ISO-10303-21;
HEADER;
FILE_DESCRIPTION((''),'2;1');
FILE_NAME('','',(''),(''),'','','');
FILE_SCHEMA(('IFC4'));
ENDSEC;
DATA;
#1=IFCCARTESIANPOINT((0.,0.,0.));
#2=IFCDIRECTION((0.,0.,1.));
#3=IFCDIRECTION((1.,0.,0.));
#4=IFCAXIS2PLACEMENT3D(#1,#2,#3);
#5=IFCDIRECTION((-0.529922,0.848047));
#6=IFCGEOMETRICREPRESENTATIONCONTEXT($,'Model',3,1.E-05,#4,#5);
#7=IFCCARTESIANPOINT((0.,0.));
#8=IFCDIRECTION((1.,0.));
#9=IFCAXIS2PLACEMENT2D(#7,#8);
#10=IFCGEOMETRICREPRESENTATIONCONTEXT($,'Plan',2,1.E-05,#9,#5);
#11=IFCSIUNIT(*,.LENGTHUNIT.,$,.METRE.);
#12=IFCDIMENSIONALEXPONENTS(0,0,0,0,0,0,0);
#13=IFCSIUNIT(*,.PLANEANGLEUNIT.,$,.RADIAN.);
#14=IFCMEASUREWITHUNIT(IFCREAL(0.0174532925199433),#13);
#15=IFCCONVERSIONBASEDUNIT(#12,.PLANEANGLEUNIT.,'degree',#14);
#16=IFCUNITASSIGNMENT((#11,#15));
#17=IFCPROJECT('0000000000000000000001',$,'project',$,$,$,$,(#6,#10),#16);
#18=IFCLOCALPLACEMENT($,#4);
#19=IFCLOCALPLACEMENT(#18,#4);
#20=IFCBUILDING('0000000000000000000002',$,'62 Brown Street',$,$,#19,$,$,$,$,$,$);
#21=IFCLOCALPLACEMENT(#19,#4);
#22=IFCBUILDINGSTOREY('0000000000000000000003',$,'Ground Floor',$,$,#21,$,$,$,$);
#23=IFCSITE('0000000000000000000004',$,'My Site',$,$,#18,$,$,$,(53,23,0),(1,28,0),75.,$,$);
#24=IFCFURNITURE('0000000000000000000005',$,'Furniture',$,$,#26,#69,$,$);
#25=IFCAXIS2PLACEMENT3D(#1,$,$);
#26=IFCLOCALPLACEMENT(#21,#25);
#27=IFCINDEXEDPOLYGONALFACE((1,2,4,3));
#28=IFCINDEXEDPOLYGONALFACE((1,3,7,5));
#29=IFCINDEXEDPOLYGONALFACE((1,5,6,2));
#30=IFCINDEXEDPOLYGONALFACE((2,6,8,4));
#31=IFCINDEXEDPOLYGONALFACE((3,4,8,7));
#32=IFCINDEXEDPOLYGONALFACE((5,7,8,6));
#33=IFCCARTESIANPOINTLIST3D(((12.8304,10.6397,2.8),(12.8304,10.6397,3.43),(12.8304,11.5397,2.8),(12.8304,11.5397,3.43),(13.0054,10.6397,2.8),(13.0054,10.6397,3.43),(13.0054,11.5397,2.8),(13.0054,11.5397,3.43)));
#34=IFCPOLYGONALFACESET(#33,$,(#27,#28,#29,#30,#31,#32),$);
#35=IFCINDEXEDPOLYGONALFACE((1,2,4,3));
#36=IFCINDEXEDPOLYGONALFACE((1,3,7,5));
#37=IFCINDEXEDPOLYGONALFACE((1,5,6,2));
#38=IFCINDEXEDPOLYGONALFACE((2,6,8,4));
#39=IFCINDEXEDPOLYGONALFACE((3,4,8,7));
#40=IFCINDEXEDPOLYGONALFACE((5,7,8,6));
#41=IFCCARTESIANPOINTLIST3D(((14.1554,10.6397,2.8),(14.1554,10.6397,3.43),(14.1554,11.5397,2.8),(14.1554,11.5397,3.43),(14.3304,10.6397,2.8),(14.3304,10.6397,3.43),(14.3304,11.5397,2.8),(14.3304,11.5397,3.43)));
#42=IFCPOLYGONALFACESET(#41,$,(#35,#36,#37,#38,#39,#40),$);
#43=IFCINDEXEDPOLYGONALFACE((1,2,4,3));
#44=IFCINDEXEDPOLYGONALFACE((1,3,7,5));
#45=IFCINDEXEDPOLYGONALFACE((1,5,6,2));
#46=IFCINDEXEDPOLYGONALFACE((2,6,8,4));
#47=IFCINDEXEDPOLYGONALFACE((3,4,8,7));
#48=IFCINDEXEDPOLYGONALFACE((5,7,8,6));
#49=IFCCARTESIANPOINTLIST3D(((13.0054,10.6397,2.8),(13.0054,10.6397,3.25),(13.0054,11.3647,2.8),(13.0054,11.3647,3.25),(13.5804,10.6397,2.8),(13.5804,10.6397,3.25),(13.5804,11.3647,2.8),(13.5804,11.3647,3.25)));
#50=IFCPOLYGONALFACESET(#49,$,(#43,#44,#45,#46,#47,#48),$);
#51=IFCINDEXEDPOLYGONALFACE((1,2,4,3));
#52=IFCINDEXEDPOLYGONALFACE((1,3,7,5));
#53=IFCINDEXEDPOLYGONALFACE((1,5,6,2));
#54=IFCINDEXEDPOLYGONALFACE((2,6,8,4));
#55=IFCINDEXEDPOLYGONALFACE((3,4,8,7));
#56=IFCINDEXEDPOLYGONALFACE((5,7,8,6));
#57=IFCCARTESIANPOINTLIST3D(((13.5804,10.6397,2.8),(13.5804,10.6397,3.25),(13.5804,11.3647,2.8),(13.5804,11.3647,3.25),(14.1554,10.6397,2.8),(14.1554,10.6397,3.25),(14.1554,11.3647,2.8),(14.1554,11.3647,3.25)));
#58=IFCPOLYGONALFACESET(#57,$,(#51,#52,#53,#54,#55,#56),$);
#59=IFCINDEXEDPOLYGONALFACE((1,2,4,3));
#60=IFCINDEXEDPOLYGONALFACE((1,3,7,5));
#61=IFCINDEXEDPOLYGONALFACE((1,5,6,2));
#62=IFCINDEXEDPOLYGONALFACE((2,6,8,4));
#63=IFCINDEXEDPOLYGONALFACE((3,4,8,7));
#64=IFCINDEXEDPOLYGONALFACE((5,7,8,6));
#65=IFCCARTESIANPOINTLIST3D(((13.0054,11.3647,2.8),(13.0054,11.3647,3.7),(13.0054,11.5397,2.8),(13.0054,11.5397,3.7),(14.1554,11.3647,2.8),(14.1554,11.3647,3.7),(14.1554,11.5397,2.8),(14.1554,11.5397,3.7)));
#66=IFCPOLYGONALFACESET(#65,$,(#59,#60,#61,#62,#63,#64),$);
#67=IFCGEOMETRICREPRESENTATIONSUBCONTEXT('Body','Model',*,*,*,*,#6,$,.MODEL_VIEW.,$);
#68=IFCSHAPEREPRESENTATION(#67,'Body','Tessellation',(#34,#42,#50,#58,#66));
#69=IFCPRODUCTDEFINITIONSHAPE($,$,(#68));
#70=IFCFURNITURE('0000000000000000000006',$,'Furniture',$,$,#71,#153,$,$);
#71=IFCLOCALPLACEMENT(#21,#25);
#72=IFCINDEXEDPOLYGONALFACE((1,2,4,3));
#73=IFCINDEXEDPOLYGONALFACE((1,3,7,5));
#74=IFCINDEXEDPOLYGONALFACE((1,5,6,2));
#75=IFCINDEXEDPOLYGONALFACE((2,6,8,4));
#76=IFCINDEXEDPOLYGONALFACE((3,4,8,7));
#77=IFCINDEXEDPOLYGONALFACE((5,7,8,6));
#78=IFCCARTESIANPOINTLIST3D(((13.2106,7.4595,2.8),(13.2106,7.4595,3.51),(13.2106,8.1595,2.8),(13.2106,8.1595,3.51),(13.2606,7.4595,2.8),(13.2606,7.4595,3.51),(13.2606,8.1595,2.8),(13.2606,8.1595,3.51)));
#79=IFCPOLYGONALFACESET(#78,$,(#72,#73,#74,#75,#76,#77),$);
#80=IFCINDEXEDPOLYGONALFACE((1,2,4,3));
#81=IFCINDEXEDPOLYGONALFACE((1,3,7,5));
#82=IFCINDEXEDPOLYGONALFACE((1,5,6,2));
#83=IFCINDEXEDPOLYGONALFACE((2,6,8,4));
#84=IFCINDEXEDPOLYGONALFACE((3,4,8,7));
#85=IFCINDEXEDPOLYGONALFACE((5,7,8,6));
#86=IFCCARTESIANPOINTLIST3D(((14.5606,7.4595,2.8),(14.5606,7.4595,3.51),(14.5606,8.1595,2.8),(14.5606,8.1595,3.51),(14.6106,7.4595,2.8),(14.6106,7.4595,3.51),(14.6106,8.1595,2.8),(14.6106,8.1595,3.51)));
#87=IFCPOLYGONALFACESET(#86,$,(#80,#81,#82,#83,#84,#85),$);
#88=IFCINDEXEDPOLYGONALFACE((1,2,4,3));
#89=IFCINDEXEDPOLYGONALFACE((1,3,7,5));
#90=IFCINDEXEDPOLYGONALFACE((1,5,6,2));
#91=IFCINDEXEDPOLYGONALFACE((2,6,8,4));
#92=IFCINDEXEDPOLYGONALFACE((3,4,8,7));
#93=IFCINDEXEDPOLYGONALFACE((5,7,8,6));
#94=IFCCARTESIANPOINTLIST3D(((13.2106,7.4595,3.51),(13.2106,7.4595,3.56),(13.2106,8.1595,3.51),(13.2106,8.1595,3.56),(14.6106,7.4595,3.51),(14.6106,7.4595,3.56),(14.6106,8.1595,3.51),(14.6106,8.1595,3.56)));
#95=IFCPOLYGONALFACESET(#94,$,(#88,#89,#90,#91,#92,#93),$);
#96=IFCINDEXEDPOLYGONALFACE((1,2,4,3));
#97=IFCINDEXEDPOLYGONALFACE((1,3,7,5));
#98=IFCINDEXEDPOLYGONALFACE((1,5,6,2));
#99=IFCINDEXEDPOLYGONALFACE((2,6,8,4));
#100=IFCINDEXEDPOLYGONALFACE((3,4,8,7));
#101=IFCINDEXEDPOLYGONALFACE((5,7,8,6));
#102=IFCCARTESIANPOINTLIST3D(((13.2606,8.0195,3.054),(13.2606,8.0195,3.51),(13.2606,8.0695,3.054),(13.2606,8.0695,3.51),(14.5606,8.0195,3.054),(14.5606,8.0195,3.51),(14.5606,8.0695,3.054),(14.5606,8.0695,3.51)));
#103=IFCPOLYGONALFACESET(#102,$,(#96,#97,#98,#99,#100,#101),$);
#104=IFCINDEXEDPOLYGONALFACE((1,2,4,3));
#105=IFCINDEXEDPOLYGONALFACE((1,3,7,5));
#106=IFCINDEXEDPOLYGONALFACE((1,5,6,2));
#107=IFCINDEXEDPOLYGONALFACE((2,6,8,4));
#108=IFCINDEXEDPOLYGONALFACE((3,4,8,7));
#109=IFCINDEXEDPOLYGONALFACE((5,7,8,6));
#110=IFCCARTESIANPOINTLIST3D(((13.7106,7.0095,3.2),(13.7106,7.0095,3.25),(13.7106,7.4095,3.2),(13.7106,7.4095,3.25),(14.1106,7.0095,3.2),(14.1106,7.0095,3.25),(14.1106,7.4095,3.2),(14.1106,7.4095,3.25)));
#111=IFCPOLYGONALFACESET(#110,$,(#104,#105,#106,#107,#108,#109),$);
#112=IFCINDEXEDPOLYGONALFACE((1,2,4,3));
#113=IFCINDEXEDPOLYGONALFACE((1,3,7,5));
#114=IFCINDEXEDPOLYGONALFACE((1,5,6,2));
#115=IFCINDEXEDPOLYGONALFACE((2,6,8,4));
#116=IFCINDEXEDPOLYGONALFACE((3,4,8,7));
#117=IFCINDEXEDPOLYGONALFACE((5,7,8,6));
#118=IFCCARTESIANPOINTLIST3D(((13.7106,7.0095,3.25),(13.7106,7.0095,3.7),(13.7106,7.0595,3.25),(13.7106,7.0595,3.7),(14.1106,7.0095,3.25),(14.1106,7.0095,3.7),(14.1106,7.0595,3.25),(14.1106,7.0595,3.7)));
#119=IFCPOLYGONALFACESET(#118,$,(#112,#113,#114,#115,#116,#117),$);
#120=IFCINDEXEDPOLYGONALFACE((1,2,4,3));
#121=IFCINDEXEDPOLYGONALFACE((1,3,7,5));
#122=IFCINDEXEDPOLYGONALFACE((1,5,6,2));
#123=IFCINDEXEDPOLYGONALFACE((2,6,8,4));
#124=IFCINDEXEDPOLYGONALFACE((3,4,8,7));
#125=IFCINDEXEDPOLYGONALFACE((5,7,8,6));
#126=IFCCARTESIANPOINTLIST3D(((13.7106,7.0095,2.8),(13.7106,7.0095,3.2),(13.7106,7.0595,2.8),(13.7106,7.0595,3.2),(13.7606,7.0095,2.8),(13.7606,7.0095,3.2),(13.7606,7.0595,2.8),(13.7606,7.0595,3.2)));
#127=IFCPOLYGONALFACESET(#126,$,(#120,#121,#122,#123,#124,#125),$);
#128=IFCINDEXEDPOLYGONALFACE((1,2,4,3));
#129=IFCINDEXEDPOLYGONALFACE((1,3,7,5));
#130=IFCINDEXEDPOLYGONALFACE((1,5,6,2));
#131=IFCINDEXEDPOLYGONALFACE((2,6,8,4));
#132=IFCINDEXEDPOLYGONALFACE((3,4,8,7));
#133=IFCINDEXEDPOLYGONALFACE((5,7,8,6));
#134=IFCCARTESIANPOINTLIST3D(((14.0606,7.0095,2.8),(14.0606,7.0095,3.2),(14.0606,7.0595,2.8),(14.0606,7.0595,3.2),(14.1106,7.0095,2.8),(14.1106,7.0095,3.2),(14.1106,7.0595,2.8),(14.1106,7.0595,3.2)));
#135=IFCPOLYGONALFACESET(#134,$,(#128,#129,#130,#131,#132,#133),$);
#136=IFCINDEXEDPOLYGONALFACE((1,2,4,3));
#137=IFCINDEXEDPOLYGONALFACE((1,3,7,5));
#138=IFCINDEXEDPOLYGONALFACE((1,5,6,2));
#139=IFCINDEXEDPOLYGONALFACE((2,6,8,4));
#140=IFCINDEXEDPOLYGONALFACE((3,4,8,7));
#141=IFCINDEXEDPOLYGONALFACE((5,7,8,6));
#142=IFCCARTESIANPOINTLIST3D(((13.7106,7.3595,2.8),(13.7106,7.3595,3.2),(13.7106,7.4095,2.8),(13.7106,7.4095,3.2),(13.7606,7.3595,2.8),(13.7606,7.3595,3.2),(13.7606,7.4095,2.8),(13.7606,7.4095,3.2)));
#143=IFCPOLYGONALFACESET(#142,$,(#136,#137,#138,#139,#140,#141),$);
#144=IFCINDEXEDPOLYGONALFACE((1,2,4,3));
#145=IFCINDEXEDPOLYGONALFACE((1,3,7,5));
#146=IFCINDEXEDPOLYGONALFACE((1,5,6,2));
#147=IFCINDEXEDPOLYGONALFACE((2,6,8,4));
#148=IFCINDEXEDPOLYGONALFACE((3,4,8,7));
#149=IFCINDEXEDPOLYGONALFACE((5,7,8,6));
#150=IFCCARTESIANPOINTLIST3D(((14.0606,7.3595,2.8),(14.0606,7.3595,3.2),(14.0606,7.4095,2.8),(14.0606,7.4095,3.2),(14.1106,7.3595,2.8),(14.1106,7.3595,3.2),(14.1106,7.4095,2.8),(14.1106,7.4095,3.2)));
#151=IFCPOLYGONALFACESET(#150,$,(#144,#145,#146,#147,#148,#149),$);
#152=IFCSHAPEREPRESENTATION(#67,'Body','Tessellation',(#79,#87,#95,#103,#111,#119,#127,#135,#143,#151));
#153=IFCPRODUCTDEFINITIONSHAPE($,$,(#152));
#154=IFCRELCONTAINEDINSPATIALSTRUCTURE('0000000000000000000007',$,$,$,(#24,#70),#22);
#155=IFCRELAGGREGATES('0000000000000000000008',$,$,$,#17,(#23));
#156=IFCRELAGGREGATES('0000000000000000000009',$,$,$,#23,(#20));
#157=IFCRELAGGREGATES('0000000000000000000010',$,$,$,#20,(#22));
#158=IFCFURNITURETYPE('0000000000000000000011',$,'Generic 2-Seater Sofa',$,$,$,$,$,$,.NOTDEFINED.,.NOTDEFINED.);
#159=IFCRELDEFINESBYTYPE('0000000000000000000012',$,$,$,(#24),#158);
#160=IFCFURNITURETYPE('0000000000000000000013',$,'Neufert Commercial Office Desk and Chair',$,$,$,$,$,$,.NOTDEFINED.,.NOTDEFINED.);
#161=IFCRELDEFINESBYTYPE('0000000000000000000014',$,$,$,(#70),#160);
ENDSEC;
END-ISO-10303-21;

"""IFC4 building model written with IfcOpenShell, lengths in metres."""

from ifc_helpers import new_model, entity, si_unit, converted_unit, direction, frame, origin_with_axes, origin_2d_with_axis, place, context, subcontext, project, spatial, line, indexed_curve, outline, extrude, shape, source, transform, mapped, type_object, type_shapes, element, save


model = new_model("IFC4")

# Units and contexts
model_context = context("Model", 3, precision=1e-05, world=origin_with_axes(), true_north=direction((-0.529922, 0.848047)))
plan_context = context("Plan", 2, precision=1e-05, world=origin_2d_with_axis(), true_north=direction((-0.529922, 0.848047)))
body_context_1 = subcontext(model_context, "Body", "Model", "MODEL_VIEW")
body_context_2 = subcontext(plan_context, "Body", "Plan", "PLAN_VIEW")
ifc_project = project(units=[si_unit("LENGTHUNIT", "METRE"), converted_unit("PLANEANGLEUNIT", "degree", entity("IfcReal", 0.0174532925199433), si_unit("PLANEANGLEUNIT", "RADIAN"), dimensions=[0, 0, 0, 0, 0, 0, 0])], contexts=[model_context, plan_context])

# Site, building, storey
site_placement = place(None, origin_with_axes())
site = spatial("IfcSite", under=ifc_project, at=site_placement, Name="My Site", RefLatitude=(53, 23, 0), RefLongitude=(1, 28, 0), RefElevation=75.0)
building_placement = place(site_placement, origin_with_axes())
building = spatial("IfcBuilding", under=site, at=building_placement, Name="62 Brown Street")
storey_placement = place(building_placement, origin_with_axes())
storey = spatial("IfcBuildingStorey", under=building, at=storey_placement, Name="Ground Floor")

# Furniture
furniture_type_1 = type_object("IfcFurnitureType", Name="Generic 2-Seater Sofa", AssemblyPlace="NOTDEFINED", PredefinedType="NOTDEFINED")
shared_shape_1 = source(origin_with_axes(), body_context_1, "Body", "SweptSolid", [
    extrude(outline(indexed_curve([(0.0, 0.0), (0.175, 0.0), (0.175, 0.9), (0.0, 0.9)], segments=[line(1, 2, 3, 4, 1)])), frame((-0.75, -0.9, 0.0), z_axis=(0.0, 0.0, 1.0), x_axis=(1.0, 0.0, 0.0)), (0.0, 0.0, 1.0), 0.63),
    extrude(outline(indexed_curve([(0.0, 0.0), (0.175, 0.0), (0.175, 0.9), (0.0, 0.9)], segments=[line(1, 2, 3, 4, 1)])), frame((0.575, -0.9, 0.0), z_axis=(0.0, 0.0, 1.0), x_axis=(1.0, 0.0, 0.0)), (0.0, 0.0, 1.0), 0.63),
    extrude(outline(indexed_curve([(0.175, 0.0), (0.75, 0.0), (0.75, 0.725), (0.175, 0.725)], segments=[line(1, 2, 3, 4, 1)])), frame((-0.75, -0.9, 0.0), z_axis=(0.0, 0.0, 1.0), x_axis=(1.0, 0.0, 0.0)), (0.0, 0.0, 1.0), 0.45),
    extrude(outline(indexed_curve([(0.75, 0.0), (1.325, 0.0), (1.325, 0.725), (0.75, 0.725)], segments=[line(1, 2, 3, 4, 1)])), frame((-0.75, -0.9, 0.0), z_axis=(0.0, 0.0, 1.0), x_axis=(1.0, 0.0, 0.0)), (0.0, 0.0, 1.0), 0.45),
    extrude(outline(indexed_curve([(0.175, 0.725), (1.325, 0.725), (1.325, 0.9), (0.175, 0.9)], segments=[line(1, 2, 3, 4, 1)])), frame((-0.75, -0.9, 0.0), z_axis=(0.0, 0.0, 1.0), x_axis=(1.0, 0.0, 0.0)), (0.0, 0.0, 1.0), 0.9),
])
shared_shape_2 = source(origin_with_axes(), body_context_2, "Body", "Curve2D", [
    entity("IfcIndexedPolyCurve", entity("IfcCartesianPointList2D", [[-0.75, -0.9], [-0.575, -0.9], [-0.575, 0.0], [-0.75, 0.0]]), [entity("IfcLineIndex", [1, 2, 3, 4, 1])]),
    entity("IfcIndexedPolyCurve", entity("IfcCartesianPointList2D", [[0.575, -0.9], [0.75, -0.9], [0.75, 0.0], [0.575, 0.0]]), [entity("IfcLineIndex", [1, 2, 3, 4, 1])]),
    entity("IfcIndexedPolyCurve", entity("IfcCartesianPointList2D", [[-0.575, -0.9], [0.0, -0.9], [0.0, -0.175], [-0.575, -0.175]]), [entity("IfcLineIndex", [1, 2, 3, 4, 1])]),
    entity("IfcIndexedPolyCurve", entity("IfcCartesianPointList2D", [[0.0, -0.9], [0.575, -0.9], [0.575, -0.175], [0.0, -0.175]]), [entity("IfcLineIndex", [1, 2, 3, 4, 1])]),
    entity("IfcIndexedPolyCurve", entity("IfcCartesianPointList2D", [[-0.575, -0.175], [0.575, -0.175], [0.575, 0.0], [-0.575, 0.0]]), [entity("IfcLineIndex", [1, 2, 3, 4, 1])]),
])
type_shapes(furniture_type_1, [shared_shape_1, shared_shape_2])
for number, where, z_axis, x_axis, name in (
    (1, (13.5804, 11.5397, 2.8), (0.0, 0.0, 1.0), (1.0, 0.0, 0.0), "Furniture"),
):
    element("IfcFurniture", number, at=place(storey_placement, frame(where, z_axis=z_axis, x_axis=x_axis)), inside=storey, type_object=furniture_type_1, Name=name, shapes=[
        shape(body_context_1, "Body", "MappedRepresentation", [mapped(shared_shape_1, transform((0.0, 0.0, 0.0), x_axis=(1.0, 0.0, 0.0), y_axis=(0.0, 1.0, 0.0), z_axis=(0.0, 0.0, 1.0), scale=1.0))]),
        shape(body_context_2, "Body", "MappedRepresentation", [mapped(shared_shape_2, transform((0.0, 0.0, 0.0), x_axis=(1.0, 0.0, 0.0), y_axis=(0.0, 1.0, 0.0), z_axis=(0.0, 0.0, 1.0), scale=1.0))]),
    ])
furniture_type_2 = type_object("IfcFurnitureType", Name="Neufert Commercial Office Desk and Chair", AssemblyPlace="NOTDEFINED", PredefinedType="NOTDEFINED")
shared_shape_3 = source(origin_with_axes(), body_context_1, "Body", "SweptSolid", [
    extrude(outline(indexed_curve([(0.0, 0.0), (0.05, 0.0), (0.05, 0.7), (0.0, 0.7)], segments=[line(1, 2, 3, 4, 1)])), frame((0.0, 0.45, 0.0), z_axis=(0.0, 0.0, 1.0), x_axis=(1.0, 0.0, 0.0)), (0.0, 0.0, 1.0), 0.71),
    extrude(outline(indexed_curve([(0.0, 0.0), (0.05, 0.0), (0.05, 0.7), (0.0, 0.7)], segments=[line(1, 2, 3, 4, 1)])), frame((1.35, 0.45, 0.0), z_axis=(0.0, 0.0, 1.0), x_axis=(1.0, 0.0, 0.0)), (0.0, 0.0, 1.0), 0.71),
    extrude(outline(indexed_curve([(0.0, 0.0), (1.4, 0.0), (1.4, 0.7), (0.0, 0.7)], segments=[line(1, 2, 3, 4, 1)])), frame((0.0, 0.45, 0.71), z_axis=(0.0, 0.0, 1.0), x_axis=(1.0, 0.0, 0.0)), (0.0, 0.0, 1.0), 0.05),
    extrude(outline(indexed_curve([(0.05, 0.56), (1.35, 0.56), (1.35, 0.61), (0.05, 0.61)], segments=[line(1, 2, 3, 4, 1)])), frame((0.0, 0.45, 0.254), z_axis=(0.0, 0.0, 1.0), x_axis=(1.0, 0.0, 0.0)), (0.0, 0.0, 1.0), 0.456),
    extrude(outline(indexed_curve([(-0.2, 0.0), (0.2, 0.0), (0.2, 0.4), (-0.2, 0.4)], segments=[line(1, 2, 3, 4, 1)])), frame((0.7, 0.0, 0.45), z_axis=(0.0, 0.0, 1.0), x_axis=(1.0, 0.0, 0.0)), (0.0, 0.0, -1.0), 0.05),
    extrude(outline(indexed_curve([(-0.2, 0.0), (0.2, 0.0), (0.2, 0.05), (-0.2, 0.05)], segments=[line(1, 2, 3, 4, 1)])), frame((0.7, 0.0, 0.9), z_axis=(0.0, 0.0, 1.0), x_axis=(1.0, 0.0, 0.0)), (0.0, 0.0, -1.0), 0.45),
    extrude(outline(indexed_curve([(-0.2, 0.0), (-0.15, 0.0), (-0.15, 0.05), (-0.2, 0.05)], segments=[line(1, 2, 3, 4, 1)])), frame((0.7, 0.0, 0.0), z_axis=(0.0, 0.0, 1.0), x_axis=(1.0, 0.0, 0.0)), (0.0, 0.0, 1.0), 0.4),
    extrude(outline(indexed_curve([(0.2, 0.0), (0.15, 0.0), (0.15, 0.05), (0.2, 0.05)], segments=[line(1, 2, 3, 4, 1)])), frame((0.7, 0.0, 0.0), z_axis=(0.0, 0.0, 1.0), x_axis=(1.0, 0.0, 0.0)), (0.0, 0.0, 1.0), 0.4),
    extrude(outline(indexed_curve([(-0.2, 0.4), (-0.15, 0.4), (-0.15, 0.35), (-0.2, 0.35)], segments=[line(1, 2, 3, 4, 1)])), frame((0.7, 0.0, 0.0), z_axis=(0.0, 0.0, 1.0), x_axis=(1.0, 0.0, 0.0)), (0.0, 0.0, 1.0), 0.4),
    extrude(outline(indexed_curve([(0.2, 0.4), (0.15, 0.4), (0.15, 0.35), (0.2, 0.35)], segments=[line(1, 2, 3, 4, 1)])), frame((0.7, 0.0, 0.0), z_axis=(0.0, 0.0, 1.0), x_axis=(1.0, 0.0, 0.0)), (0.0, 0.0, 1.0), 0.4),
])
shared_shape_4 = source(origin_with_axes(), body_context_2, "Body", "Curve2D", [
    entity("IfcIndexedPolyCurve", entity("IfcCartesianPointList2D", [[0.0, 0.45], [1.4, 0.45], [1.4, 1.15], [0.0, 1.15]]), [entity("IfcLineIndex", [1, 2, 3, 4, 1])]),
    entity("IfcIndexedPolyCurve", entity("IfcCartesianPointList2D", [[0.5, 0.4], [0.9, 0.4]])),
    entity("IfcIndexedPolyCurve", entity("IfcCartesianPointList2D", [[0.5, 0.4], [0.5, 0.2], [0.5586, 0.0586], [0.7, 0.0], [0.8414, 0.0586], [0.9, 0.2], [0.9, 0.4]]), [entity("IfcLineIndex", [1, 2]), entity("IfcArcIndex", [2, 3, 4]), entity("IfcArcIndex", [4, 5, 6]), entity("IfcLineIndex", [6, 7])]),
    entity("IfcIndexedPolyCurve", entity("IfcCartesianPointList2D", [[0.54, 0.4], [0.54, 0.2], [0.5869, 0.0869], [0.7, 0.04], [0.8131, 0.0869], [0.86, 0.2], [0.86, 0.4]]), [entity("IfcLineIndex", [1, 2]), entity("IfcArcIndex", [2, 3, 4]), entity("IfcArcIndex", [4, 5, 6]), entity("IfcLineIndex", [6, 7])]),
])
type_shapes(furniture_type_2, [shared_shape_3, shared_shape_4])
furniture_1_placement = place(storey_placement, frame((13.2106, 7.0095, 2.8), z_axis=(0.0, 0.0, 1.0), x_axis=(1.0, 0.0, 0.0)))
element("IfcFurniture", 2, at=furniture_1_placement, inside=storey, type_object=furniture_type_2, Name="Furniture", shapes=[
    shape(body_context_1, "Body", "MappedRepresentation", [mapped(shared_shape_3, transform((0.0, 0.0, 0.0), x_axis=(1.0, 0.0, 0.0), y_axis=(0.0, 1.0, 0.0), z_axis=(0.0, 0.0, 1.0), scale=1.0))]),
    shape(body_context_2, "Body", "MappedRepresentation", [mapped(shared_shape_4, transform((0.0, 0.0, 0.0), x_axis=(1.0, 0.0, 0.0), y_axis=(0.0, 1.0, 0.0), z_axis=(0.0, 0.0, 1.0), scale=1.0))]),
])

save(model, "model.ifc")
